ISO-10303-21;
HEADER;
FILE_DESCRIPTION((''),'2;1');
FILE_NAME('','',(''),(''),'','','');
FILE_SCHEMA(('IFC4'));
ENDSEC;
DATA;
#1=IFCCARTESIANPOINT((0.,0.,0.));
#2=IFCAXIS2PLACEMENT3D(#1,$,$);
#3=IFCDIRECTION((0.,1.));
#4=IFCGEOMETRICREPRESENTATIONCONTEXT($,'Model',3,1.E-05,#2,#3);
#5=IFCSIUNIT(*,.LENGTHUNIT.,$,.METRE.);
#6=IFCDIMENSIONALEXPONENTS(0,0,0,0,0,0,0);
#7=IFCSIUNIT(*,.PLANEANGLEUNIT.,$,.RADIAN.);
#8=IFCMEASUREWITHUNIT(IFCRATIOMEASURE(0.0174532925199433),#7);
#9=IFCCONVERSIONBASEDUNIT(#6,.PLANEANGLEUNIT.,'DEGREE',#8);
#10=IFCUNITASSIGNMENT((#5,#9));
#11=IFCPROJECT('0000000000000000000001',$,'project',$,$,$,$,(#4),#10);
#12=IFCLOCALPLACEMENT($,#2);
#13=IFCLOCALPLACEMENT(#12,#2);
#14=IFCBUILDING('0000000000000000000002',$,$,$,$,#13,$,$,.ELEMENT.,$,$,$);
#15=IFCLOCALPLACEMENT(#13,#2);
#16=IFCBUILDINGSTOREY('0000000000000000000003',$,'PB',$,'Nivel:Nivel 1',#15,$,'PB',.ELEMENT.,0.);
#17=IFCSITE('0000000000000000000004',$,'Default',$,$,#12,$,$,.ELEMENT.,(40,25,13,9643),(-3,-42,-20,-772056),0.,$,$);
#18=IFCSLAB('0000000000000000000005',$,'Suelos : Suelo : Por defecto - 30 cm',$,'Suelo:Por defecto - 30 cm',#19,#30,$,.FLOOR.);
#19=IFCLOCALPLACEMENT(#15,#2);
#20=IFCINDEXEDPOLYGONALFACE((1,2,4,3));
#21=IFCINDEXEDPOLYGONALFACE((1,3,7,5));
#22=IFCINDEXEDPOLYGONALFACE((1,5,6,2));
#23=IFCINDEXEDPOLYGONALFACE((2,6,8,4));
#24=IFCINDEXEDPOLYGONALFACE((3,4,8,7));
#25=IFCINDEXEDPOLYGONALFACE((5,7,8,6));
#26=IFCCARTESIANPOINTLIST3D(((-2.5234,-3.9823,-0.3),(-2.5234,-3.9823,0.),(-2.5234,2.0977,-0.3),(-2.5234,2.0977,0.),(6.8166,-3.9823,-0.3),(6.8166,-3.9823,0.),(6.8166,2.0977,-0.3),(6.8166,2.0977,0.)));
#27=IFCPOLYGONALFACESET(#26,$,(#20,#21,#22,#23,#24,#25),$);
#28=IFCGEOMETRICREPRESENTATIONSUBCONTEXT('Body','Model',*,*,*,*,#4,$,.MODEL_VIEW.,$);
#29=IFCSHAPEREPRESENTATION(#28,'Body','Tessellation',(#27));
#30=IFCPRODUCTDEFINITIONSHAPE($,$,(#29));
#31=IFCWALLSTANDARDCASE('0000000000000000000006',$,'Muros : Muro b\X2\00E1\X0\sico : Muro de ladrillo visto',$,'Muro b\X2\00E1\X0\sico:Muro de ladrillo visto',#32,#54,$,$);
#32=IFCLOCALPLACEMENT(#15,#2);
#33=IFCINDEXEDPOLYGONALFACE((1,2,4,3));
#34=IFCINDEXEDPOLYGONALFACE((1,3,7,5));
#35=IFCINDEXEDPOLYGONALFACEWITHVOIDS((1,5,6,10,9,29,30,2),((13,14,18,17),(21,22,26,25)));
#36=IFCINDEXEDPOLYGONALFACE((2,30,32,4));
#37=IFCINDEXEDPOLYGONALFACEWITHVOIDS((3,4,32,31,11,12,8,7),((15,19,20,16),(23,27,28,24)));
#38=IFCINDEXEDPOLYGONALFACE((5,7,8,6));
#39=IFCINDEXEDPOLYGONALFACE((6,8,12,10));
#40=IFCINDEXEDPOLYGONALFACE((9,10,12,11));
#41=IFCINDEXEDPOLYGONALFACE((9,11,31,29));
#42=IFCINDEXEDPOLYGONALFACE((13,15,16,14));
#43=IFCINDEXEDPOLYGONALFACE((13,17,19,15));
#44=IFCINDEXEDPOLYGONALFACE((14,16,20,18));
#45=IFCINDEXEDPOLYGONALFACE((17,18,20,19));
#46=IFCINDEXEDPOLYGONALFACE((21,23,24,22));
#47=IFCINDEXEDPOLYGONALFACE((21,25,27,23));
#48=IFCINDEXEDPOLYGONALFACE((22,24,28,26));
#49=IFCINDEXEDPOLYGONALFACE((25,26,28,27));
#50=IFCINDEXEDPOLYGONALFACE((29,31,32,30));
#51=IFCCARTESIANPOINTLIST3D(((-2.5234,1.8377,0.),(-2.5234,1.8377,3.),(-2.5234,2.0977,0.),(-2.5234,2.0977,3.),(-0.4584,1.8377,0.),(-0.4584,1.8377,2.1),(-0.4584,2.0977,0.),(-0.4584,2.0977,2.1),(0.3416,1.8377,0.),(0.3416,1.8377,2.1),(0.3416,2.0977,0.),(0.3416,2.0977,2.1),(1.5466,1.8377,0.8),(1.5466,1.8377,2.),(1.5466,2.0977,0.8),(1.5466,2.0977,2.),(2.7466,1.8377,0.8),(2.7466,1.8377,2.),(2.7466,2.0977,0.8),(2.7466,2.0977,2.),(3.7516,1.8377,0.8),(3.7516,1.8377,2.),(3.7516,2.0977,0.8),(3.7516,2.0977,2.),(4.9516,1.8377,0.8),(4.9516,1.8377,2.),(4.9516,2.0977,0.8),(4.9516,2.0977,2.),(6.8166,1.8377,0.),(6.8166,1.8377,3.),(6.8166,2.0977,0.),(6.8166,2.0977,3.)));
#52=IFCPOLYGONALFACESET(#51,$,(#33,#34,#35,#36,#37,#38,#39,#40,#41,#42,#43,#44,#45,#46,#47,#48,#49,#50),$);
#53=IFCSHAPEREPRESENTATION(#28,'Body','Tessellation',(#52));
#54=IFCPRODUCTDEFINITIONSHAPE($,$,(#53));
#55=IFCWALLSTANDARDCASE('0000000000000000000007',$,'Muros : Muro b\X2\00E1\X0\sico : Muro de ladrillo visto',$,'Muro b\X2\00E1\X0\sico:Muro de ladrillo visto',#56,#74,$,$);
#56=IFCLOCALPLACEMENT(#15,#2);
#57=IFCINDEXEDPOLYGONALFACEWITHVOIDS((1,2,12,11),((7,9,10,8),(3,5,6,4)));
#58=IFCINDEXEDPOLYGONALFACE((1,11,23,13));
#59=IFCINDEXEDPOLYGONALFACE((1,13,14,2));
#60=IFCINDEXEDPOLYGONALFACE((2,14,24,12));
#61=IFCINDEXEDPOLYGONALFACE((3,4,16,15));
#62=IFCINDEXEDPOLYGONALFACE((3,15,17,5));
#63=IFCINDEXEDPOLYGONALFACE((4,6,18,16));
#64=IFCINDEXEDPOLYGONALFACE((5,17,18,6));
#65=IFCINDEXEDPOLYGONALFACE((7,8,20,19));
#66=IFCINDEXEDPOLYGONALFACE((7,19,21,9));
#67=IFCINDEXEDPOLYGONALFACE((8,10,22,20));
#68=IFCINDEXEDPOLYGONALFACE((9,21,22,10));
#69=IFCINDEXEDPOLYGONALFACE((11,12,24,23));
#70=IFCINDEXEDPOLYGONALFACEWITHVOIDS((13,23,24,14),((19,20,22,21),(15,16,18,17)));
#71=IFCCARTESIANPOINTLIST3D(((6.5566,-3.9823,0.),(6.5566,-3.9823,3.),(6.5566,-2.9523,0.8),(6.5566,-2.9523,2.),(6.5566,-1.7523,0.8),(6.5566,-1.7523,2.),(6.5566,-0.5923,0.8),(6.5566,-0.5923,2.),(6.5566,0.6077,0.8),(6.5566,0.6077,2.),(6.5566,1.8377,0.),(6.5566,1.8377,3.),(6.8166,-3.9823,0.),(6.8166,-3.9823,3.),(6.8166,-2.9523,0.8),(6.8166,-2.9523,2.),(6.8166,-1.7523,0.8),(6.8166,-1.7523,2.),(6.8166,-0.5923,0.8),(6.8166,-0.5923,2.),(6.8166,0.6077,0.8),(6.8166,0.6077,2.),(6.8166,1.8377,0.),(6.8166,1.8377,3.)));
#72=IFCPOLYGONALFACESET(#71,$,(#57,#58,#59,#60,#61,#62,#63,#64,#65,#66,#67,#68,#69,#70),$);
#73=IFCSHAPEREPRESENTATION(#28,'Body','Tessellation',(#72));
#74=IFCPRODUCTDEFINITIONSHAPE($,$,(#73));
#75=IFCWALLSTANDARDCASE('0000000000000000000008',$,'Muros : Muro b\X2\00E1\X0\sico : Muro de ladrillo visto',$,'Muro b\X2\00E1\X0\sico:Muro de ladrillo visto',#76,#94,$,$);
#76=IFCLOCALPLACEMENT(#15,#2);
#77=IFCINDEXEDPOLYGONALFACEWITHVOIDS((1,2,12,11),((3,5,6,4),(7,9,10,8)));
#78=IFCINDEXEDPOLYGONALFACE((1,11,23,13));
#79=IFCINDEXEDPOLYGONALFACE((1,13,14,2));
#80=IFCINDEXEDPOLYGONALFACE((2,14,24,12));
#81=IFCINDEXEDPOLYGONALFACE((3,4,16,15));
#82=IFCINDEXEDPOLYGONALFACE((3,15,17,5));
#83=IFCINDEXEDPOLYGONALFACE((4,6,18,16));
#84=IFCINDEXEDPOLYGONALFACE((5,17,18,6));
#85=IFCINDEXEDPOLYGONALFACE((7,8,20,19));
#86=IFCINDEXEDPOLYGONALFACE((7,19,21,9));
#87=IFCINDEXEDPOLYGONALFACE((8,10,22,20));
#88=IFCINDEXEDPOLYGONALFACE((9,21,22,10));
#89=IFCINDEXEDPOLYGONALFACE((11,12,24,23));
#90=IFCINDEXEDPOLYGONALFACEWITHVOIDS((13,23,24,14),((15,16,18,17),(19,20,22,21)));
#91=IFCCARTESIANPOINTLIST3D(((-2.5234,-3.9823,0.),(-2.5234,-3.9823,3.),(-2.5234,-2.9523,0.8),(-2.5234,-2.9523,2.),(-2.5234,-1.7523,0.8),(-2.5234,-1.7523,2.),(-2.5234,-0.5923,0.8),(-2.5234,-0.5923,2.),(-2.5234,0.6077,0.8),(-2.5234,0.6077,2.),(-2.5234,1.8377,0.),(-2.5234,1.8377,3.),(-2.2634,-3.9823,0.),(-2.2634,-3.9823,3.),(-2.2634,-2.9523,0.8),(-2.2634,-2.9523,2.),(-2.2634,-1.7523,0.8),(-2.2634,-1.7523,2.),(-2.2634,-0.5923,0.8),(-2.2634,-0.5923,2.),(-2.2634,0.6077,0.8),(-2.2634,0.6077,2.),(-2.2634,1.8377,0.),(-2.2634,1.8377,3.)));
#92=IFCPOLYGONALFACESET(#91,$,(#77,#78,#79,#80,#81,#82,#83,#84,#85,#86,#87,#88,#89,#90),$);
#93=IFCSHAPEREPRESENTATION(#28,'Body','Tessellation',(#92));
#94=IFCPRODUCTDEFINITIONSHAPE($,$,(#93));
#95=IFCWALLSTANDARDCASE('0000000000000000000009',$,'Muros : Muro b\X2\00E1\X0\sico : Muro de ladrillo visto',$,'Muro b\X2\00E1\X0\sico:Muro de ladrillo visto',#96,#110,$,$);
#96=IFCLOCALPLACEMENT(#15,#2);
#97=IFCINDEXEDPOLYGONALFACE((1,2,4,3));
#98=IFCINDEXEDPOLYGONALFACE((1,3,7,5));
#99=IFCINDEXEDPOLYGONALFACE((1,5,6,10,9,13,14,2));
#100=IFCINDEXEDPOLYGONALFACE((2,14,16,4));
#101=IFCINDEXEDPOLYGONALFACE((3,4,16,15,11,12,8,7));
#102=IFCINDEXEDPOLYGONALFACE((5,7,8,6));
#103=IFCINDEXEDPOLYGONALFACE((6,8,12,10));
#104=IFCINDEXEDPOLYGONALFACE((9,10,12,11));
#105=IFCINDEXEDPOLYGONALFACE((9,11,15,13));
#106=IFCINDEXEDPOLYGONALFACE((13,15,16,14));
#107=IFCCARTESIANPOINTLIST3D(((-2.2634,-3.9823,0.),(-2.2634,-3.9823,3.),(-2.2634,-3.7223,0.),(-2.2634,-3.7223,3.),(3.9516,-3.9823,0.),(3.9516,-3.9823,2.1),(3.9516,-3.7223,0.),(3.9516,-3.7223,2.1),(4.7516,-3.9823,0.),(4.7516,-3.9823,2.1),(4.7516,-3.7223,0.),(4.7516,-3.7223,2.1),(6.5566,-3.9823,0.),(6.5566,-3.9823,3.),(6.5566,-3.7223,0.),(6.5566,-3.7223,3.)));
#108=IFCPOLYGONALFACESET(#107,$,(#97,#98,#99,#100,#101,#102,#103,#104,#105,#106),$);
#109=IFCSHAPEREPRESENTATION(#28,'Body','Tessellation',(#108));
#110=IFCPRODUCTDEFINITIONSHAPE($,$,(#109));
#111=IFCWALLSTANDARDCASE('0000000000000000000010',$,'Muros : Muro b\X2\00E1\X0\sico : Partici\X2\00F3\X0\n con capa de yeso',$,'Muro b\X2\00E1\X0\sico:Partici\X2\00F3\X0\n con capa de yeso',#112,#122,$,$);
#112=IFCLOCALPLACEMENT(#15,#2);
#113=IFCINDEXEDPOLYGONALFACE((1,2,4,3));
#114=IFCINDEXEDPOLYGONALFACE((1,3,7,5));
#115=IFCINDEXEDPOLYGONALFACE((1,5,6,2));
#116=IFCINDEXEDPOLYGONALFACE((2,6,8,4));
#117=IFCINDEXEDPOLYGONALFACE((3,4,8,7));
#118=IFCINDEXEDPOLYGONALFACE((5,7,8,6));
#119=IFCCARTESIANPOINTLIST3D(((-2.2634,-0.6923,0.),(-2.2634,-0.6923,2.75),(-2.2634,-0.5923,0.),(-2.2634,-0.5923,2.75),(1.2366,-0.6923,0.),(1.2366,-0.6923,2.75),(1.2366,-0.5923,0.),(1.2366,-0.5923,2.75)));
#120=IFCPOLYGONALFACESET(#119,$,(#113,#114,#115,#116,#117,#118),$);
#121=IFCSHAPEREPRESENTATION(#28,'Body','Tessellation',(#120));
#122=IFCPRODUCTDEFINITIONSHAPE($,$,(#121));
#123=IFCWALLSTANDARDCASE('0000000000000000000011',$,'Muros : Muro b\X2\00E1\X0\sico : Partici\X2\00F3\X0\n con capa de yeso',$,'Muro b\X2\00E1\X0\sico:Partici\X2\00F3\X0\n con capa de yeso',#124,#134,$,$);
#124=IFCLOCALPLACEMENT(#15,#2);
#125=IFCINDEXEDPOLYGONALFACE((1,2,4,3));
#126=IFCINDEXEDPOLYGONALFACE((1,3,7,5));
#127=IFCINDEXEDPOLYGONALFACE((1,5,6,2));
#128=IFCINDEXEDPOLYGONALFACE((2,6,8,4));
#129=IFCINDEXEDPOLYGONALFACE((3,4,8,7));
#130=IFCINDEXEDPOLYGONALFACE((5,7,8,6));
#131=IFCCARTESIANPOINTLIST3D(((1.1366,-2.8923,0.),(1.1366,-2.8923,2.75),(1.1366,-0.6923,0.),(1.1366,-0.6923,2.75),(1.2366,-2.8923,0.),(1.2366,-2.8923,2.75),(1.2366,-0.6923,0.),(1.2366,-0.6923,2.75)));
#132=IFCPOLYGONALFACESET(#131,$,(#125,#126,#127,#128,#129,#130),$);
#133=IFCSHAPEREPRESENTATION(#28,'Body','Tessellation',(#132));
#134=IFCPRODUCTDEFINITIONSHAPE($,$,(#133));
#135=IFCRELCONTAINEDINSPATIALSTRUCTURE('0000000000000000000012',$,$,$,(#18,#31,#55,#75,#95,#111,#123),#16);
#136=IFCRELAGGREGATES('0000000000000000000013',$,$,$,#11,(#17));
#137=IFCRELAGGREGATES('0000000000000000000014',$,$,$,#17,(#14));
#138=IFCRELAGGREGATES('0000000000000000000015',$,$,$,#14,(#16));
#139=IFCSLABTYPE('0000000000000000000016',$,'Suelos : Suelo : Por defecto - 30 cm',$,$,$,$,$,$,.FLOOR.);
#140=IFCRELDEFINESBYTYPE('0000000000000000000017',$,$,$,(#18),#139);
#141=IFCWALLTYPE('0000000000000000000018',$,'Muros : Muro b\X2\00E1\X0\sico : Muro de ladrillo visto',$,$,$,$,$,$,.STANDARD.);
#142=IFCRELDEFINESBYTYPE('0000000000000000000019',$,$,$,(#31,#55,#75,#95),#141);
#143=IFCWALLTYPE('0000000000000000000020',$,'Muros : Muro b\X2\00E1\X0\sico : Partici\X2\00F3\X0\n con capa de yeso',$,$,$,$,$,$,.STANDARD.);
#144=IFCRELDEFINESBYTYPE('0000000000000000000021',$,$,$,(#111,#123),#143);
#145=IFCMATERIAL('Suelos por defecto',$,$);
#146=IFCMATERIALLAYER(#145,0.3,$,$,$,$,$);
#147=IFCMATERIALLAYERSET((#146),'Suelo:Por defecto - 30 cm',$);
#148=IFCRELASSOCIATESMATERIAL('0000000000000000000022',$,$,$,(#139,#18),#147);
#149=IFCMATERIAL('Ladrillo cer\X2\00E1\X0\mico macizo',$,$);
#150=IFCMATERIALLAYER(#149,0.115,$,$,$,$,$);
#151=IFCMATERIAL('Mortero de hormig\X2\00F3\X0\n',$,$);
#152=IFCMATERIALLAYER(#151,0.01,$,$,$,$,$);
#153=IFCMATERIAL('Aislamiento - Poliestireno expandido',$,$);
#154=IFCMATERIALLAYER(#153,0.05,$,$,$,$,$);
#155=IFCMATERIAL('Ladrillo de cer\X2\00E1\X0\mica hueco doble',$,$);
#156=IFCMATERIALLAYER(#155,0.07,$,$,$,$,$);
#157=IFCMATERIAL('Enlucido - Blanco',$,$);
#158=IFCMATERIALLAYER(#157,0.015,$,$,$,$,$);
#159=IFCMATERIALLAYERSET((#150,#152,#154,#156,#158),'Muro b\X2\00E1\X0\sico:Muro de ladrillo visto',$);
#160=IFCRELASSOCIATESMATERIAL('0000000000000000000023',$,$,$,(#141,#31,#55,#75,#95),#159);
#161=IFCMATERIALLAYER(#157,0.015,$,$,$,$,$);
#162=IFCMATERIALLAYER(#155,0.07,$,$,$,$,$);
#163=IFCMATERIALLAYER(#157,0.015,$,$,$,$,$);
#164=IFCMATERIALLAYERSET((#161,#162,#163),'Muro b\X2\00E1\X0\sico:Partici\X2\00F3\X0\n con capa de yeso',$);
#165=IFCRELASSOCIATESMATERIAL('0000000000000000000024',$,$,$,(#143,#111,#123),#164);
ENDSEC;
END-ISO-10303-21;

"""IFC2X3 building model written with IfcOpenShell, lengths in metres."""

from ifc_helpers import new_model, entity, si_unit, converted_unit, direction, frame, frame_2d, origin, place, context, subcontext, project, spatial, rectangle, extrude, material, layer, layer_set, layer_usage, type_object, element, save


model = new_model("IFC2X3")

# Units and contexts
model_context = context("Model", 3, precision=1e-05, world=origin(), true_north=direction((0.0, 1.0)))
body_context = subcontext(model_context, "Body", "Model", "MODEL_VIEW")
ifc_project = project(units=[si_unit("LENGTHUNIT", "METRE"), converted_unit("PLANEANGLEUNIT", "DEGREE", entity("IfcRatioMeasure", 0.0174532925199433), si_unit("PLANEANGLEUNIT", "RADIAN"), dimensions=[0, 0, 0, 0, 0, 0, 0])], contexts=[model_context])

# Site, building, storey
site_placement = place(None, origin())
site = spatial("IfcSite", under=ifc_project, at=site_placement, Name="Default", CompositionType="ELEMENT", RefLatitude=(40, 25, 13, 9643), RefLongitude=(-3, -42, -20, -772056), RefElevation=0.0)
building_placement = place(site_placement, origin())
building = spatial("IfcBuilding", under=site, at=building_placement, CompositionType="ELEMENT")
storey_placement = place(building_placement, origin())
storey = spatial("IfcBuildingStorey", under=building, at=storey_placement, Name="PB", ObjectType="Nivel:Nivel 1", LongName="PB", CompositionType="ELEMENT", Elevation=0.0)

# Slab
ifc_material_1 = material(Name="Suelos por defecto")
ifc_layer_1 = layer(ifc_material_1, 0.3)
ifc_layer_set_1 = layer_set([ifc_layer_1], Name="Suelo:Por defecto - 30 cm")
ifc_layer_usage_1 = layer_usage(ifc_layer_set_1, "AXIS3", "POSITIVE", 0.0)
slab_type = type_object("IfcSlabType", Name="Suelos : Suelo : Por defecto - 30 cm", PredefinedType="FLOOR", material=ifc_layer_set_1)
slab_placement = place(storey_placement, origin())
element("IfcSlab", 1, at=slab_placement, inside=storey, type_object=slab_type, material=ifc_layer_usage_1, Name="Suelos : Suelo : Por defecto - 30 cm", ObjectType="Suelo:Por defecto - 30 cm", PredefinedType="FLOOR", context=body_context, shape_type="SweptSolid", body=[
    extrude(rectangle(XDim=6.08, YDim=9.34, at=frame_2d((0.0, 0.0), x_axis=(1.0, 0.0))), frame((2.1466, -0.9423, 0.0), z_axis=(0.0, 0.0, -1.0), x_axis=(0.0, 1.0, 0.0)), (0.0, 0.0, 1.0), 0.3),
])

# Walls, openings
ifc_material_2 = material(Name="Ladrillo cerámico macizo")
ifc_layer_2 = layer(ifc_material_2, 0.115)
ifc_material_3 = material(Name="Mortero de hormigón")
ifc_layer_3 = layer(ifc_material_3, 0.01)
ifc_material_4 = material(Name="Aislamiento - Poliestireno expandido")
ifc_layer_4 = layer(ifc_material_4, 0.05)
ifc_material_5 = material(Name="Ladrillo de cerámica hueco doble")
ifc_layer_5 = layer(ifc_material_5, 0.07)
ifc_material_6 = material(Name="Enlucido - Blanco")
ifc_layer_6 = layer(ifc_material_6, 0.015)
ifc_layer_set_2 = layer_set([ifc_layer_2, ifc_layer_3, ifc_layer_4, ifc_layer_5, ifc_layer_6], Name="Muro básico:Muro de ladrillo visto")
ifc_layer_usage_2 = layer_usage(ifc_layer_set_2, "AXIS2", "NEGATIVE", 0.13)
wall_type_1 = type_object("IfcWallType", Name="Muros : Muro básico : Muro de ladrillo visto", PredefinedType="STANDARD", material=ifc_layer_set_2)
wall_1_placement = place(storey_placement, frame((-2.5234, 1.9677, 0.0)))
wall_1 = element("IfcWallStandardCase", 2, at=wall_1_placement, inside=storey, type_object=wall_type_1, material=ifc_layer_usage_2, Name="Muros : Muro básico : Muro de ladrillo visto", ObjectType="Muro básico:Muro de ladrillo visto", context=body_context, shape_type="SweptSolid", body=[
    extrude(rectangle(XDim=9.34, YDim=0.26, at=frame_2d((4.67, 0.0), x_axis=(-1.0, 0.0))), origin(), (0.0, 0.0, 1.0), 3.0),
])
opening_1_placement = place(wall_1_placement, frame((2.865, 0.13, 0.0)))
element("IfcOpeningElement", 3, at=opening_1_placement, cuts=wall_1, ObjectType="Opening", context=body_context, shape_type="SweptSolid", body=[
    extrude(rectangle(XDim=2.1, YDim=0.8, at=frame_2d((1.05, 0.4), x_axis=(1.0, 0.0))), frame((0.0, 0.0, 0.0), z_axis=(0.0, -1.0, 0.0), x_axis=(0.0, 0.0, 1.0)), (0.0, 0.0, 1.0), 0.26),
])
opening_2_placement = place(wall_1_placement, frame((5.27, 0.13, 0.8)))
element("IfcOpeningElement", 4, at=opening_2_placement, cuts=wall_1, ObjectType="Opening", context=body_context, shape_type="SweptSolid", body=[
    extrude(rectangle(XDim=1.2, YDim=1.2, at=frame_2d((0.6, 0.6), x_axis=(1.0, 0.0))), frame((0.0, 0.0, 0.0), z_axis=(0.0, -1.0, 0.0), x_axis=(0.0, 0.0, 1.0)), (0.0, 0.0, 1.0), 0.26),
])
opening_3_placement = place(wall_1_placement, frame((7.475, 0.13, 0.8)))
element("IfcOpeningElement", 5, at=opening_3_placement, cuts=wall_1, ObjectType="Opening", context=body_context, shape_type="SweptSolid", body=[
    extrude(rectangle(XDim=1.2, YDim=1.2, at=frame_2d((0.6, 0.6), x_axis=(1.0, 0.0))), frame((0.0, 0.0, 0.0), z_axis=(0.0, -1.0, 0.0), x_axis=(0.0, 0.0, 1.0)), (0.0, 0.0, 1.0), 0.26),
])
ifc_layer_usage_3 = layer_usage(ifc_layer_set_2, "AXIS2", "NEGATIVE", 0.13)
wall_2_placement = place(storey_placement, frame((6.6866, 1.8377, 0.0), z_axis=(0.0, 0.0, 1.0), x_axis=(0.0, -1.0, 0.0)))
wall_2 = element("IfcWallStandardCase", 6, at=wall_2_placement, inside=storey, type_object=wall_type_1, material=ifc_layer_usage_3, Name="Muros : Muro básico : Muro de ladrillo visto", ObjectType="Muro básico:Muro de ladrillo visto", context=body_context, shape_type="SweptSolid", body=[
    extrude(rectangle(XDim=5.82, YDim=0.26, at=frame_2d((2.91, 0.0), x_axis=(-1.0, 0.0))), origin(), (0.0, 0.0, 1.0), 3.0),
])
opening_4_placement = place(wall_2_placement, frame((1.23, -0.13, 0.8)))
element("IfcOpeningElement", 7, at=opening_4_placement, cuts=wall_2, ObjectType="Opening", context=body_context, shape_type="SweptSolid", body=[
    extrude(rectangle(XDim=1.2, YDim=1.2, at=frame_2d((0.6, 0.6), x_axis=(1.0, 0.0))), frame((0.0, 0.0, 0.0), z_axis=(0.0, 1.0, 0.0), x_axis=(0.0, 0.0, 1.0)), (0.0, 0.0, 1.0), 0.26),
])
opening_5_placement = place(wall_2_placement, frame((3.59, -0.13, 0.8)))
element("IfcOpeningElement", 8, at=opening_5_placement, cuts=wall_2, ObjectType="Opening", context=body_context, shape_type="SweptSolid", body=[
    extrude(rectangle(XDim=1.2, YDim=1.2, at=frame_2d((0.6, 0.6), x_axis=(1.0, 0.0))), frame((0.0, 0.0, 0.0), z_axis=(0.0, 1.0, 0.0), x_axis=(0.0, 0.0, 1.0)), (0.0, 0.0, 1.0), 0.26),
])
ifc_layer_usage_4 = layer_usage(ifc_layer_set_2, "AXIS2", "POSITIVE", -0.13)
wall_3_placement = place(storey_placement, frame((-2.3934, 1.8377, 0.0), z_axis=(0.0, 0.0, 1.0), x_axis=(0.0, -1.0, 0.0)))
wall_3 = element("IfcWallStandardCase", 9, at=wall_3_placement, inside=storey, type_object=wall_type_1, material=ifc_layer_usage_4, Name="Muros : Muro básico : Muro de ladrillo visto", ObjectType="Muro básico:Muro de ladrillo visto", context=body_context, shape_type="SweptSolid", body=[
    extrude(rectangle(XDim=5.82, YDim=0.26, at=frame_2d((2.91, 0.0), x_axis=(-1.0, 0.0))), origin(), (0.0, 0.0, 1.0), 3.0),
])
opening_6_placement = place(wall_3_placement, frame((1.23, -0.13, 0.8)))
element("IfcOpeningElement", 10, at=opening_6_placement, cuts=wall_3, ObjectType="Opening", context=body_context, shape_type="SweptSolid", body=[
    extrude(rectangle(XDim=1.2, YDim=1.2, at=frame_2d((0.6, 0.6), x_axis=(1.0, 0.0))), frame((0.0, 0.0, 0.0), z_axis=(0.0, 1.0, 0.0), x_axis=(0.0, 0.0, 1.0)), (0.0, 0.0, 1.0), 0.26),
])
opening_7_placement = place(wall_3_placement, frame((3.59, -0.13, 0.8)))
element("IfcOpeningElement", 11, at=opening_7_placement, cuts=wall_3, ObjectType="Opening", context=body_context, shape_type="SweptSolid", body=[
    extrude(rectangle(XDim=1.2, YDim=1.2, at=frame_2d((0.6, 0.6), x_axis=(1.0, 0.0))), frame((0.0, 0.0, 0.0), z_axis=(0.0, 1.0, 0.0), x_axis=(0.0, 0.0, 1.0)), (0.0, 0.0, 1.0), 0.26),
])

# Wall, opening
ifc_layer_usage_5 = layer_usage(ifc_layer_set_2, "AXIS2", "POSITIVE", -0.13)
wall_4_placement = place(storey_placement, frame((-2.2634, -3.8523, 0.0)))
wall_4 = element("IfcWallStandardCase", 12, at=wall_4_placement, inside=storey, type_object=wall_type_1, material=ifc_layer_usage_5, Name="Muros : Muro básico : Muro de ladrillo visto", ObjectType="Muro básico:Muro de ladrillo visto", context=body_context, shape_type="SweptSolid", body=[
    extrude(rectangle(XDim=8.82, YDim=0.26, at=frame_2d((4.41, 0.0), x_axis=(-1.0, 0.0))), origin(), (0.0, 0.0, 1.0), 3.0),
])
opening_8_placement = place(wall_4_placement, frame((6.215, -0.13, 0.0)))
element("IfcOpeningElement", 13, at=opening_8_placement, cuts=wall_4, ObjectType="Opening", context=body_context, shape_type="SweptSolid", body=[
    extrude(rectangle(XDim=2.1, YDim=0.8, at=frame_2d((1.05, 0.4), x_axis=(1.0, 0.0))), frame((0.0, 0.0, 0.0), z_axis=(0.0, 1.0, 0.0), x_axis=(0.0, 0.0, 1.0)), (0.0, 0.0, 1.0), 0.26),
])

# Walls
ifc_layer_7 = layer(ifc_material_6, 0.015)
ifc_layer_8 = layer(ifc_material_5, 0.07)
ifc_layer_9 = layer(ifc_material_6, 0.015)
ifc_layer_set_3 = layer_set([ifc_layer_7, ifc_layer_8, ifc_layer_9], Name="Muro básico:Partición con capa de yeso")
ifc_layer_usage_6 = layer_usage(ifc_layer_set_3, "AXIS2", "NEGATIVE", 0.05)
wall_type_2 = type_object("IfcWallType", Name="Muros : Muro básico : Partición con capa de yeso", PredefinedType="STANDARD", material=ifc_layer_set_3)
wall_5_placement = place(storey_placement, frame((-2.2634, -0.6423, 0.0)))
element("IfcWallStandardCase", 14, at=wall_5_placement, inside=storey, type_object=wall_type_2, material=ifc_layer_usage_6, Name="Muros : Muro básico : Partición con capa de yeso", ObjectType="Muro básico:Partición con capa de yeso", context=body_context, shape_type="SweptSolid", body=[
    extrude(rectangle(XDim=3.5, YDim=0.1, at=frame_2d((1.75, 0.0), x_axis=(-1.0, 0.0))), origin(), (0.0, 0.0, 1.0), 2.75),
])
ifc_layer_usage_7 = layer_usage(ifc_layer_set_3, "AXIS2", "NEGATIVE", 0.05)
wall_6_placement = place(storey_placement, frame((1.1866, -0.6923, 0.0), z_axis=(0.0, 0.0, 1.0), x_axis=(0.0, -1.0, 0.0)))
element("IfcWallStandardCase", 15, at=wall_6_placement, inside=storey, type_object=wall_type_2, material=ifc_layer_usage_7, Name="Muros : Muro básico : Partición con capa de yeso", ObjectType="Muro básico:Partición con capa de yeso", context=body_context, shape_type="SweptSolid", body=[
    extrude(rectangle(XDim=2.2, YDim=0.1, at=frame_2d((1.1, 0.0), x_axis=(-1.0, 0.0))), origin(), (0.0, 0.0, 1.0), 2.75),
])

save(model, "model.ifc")
